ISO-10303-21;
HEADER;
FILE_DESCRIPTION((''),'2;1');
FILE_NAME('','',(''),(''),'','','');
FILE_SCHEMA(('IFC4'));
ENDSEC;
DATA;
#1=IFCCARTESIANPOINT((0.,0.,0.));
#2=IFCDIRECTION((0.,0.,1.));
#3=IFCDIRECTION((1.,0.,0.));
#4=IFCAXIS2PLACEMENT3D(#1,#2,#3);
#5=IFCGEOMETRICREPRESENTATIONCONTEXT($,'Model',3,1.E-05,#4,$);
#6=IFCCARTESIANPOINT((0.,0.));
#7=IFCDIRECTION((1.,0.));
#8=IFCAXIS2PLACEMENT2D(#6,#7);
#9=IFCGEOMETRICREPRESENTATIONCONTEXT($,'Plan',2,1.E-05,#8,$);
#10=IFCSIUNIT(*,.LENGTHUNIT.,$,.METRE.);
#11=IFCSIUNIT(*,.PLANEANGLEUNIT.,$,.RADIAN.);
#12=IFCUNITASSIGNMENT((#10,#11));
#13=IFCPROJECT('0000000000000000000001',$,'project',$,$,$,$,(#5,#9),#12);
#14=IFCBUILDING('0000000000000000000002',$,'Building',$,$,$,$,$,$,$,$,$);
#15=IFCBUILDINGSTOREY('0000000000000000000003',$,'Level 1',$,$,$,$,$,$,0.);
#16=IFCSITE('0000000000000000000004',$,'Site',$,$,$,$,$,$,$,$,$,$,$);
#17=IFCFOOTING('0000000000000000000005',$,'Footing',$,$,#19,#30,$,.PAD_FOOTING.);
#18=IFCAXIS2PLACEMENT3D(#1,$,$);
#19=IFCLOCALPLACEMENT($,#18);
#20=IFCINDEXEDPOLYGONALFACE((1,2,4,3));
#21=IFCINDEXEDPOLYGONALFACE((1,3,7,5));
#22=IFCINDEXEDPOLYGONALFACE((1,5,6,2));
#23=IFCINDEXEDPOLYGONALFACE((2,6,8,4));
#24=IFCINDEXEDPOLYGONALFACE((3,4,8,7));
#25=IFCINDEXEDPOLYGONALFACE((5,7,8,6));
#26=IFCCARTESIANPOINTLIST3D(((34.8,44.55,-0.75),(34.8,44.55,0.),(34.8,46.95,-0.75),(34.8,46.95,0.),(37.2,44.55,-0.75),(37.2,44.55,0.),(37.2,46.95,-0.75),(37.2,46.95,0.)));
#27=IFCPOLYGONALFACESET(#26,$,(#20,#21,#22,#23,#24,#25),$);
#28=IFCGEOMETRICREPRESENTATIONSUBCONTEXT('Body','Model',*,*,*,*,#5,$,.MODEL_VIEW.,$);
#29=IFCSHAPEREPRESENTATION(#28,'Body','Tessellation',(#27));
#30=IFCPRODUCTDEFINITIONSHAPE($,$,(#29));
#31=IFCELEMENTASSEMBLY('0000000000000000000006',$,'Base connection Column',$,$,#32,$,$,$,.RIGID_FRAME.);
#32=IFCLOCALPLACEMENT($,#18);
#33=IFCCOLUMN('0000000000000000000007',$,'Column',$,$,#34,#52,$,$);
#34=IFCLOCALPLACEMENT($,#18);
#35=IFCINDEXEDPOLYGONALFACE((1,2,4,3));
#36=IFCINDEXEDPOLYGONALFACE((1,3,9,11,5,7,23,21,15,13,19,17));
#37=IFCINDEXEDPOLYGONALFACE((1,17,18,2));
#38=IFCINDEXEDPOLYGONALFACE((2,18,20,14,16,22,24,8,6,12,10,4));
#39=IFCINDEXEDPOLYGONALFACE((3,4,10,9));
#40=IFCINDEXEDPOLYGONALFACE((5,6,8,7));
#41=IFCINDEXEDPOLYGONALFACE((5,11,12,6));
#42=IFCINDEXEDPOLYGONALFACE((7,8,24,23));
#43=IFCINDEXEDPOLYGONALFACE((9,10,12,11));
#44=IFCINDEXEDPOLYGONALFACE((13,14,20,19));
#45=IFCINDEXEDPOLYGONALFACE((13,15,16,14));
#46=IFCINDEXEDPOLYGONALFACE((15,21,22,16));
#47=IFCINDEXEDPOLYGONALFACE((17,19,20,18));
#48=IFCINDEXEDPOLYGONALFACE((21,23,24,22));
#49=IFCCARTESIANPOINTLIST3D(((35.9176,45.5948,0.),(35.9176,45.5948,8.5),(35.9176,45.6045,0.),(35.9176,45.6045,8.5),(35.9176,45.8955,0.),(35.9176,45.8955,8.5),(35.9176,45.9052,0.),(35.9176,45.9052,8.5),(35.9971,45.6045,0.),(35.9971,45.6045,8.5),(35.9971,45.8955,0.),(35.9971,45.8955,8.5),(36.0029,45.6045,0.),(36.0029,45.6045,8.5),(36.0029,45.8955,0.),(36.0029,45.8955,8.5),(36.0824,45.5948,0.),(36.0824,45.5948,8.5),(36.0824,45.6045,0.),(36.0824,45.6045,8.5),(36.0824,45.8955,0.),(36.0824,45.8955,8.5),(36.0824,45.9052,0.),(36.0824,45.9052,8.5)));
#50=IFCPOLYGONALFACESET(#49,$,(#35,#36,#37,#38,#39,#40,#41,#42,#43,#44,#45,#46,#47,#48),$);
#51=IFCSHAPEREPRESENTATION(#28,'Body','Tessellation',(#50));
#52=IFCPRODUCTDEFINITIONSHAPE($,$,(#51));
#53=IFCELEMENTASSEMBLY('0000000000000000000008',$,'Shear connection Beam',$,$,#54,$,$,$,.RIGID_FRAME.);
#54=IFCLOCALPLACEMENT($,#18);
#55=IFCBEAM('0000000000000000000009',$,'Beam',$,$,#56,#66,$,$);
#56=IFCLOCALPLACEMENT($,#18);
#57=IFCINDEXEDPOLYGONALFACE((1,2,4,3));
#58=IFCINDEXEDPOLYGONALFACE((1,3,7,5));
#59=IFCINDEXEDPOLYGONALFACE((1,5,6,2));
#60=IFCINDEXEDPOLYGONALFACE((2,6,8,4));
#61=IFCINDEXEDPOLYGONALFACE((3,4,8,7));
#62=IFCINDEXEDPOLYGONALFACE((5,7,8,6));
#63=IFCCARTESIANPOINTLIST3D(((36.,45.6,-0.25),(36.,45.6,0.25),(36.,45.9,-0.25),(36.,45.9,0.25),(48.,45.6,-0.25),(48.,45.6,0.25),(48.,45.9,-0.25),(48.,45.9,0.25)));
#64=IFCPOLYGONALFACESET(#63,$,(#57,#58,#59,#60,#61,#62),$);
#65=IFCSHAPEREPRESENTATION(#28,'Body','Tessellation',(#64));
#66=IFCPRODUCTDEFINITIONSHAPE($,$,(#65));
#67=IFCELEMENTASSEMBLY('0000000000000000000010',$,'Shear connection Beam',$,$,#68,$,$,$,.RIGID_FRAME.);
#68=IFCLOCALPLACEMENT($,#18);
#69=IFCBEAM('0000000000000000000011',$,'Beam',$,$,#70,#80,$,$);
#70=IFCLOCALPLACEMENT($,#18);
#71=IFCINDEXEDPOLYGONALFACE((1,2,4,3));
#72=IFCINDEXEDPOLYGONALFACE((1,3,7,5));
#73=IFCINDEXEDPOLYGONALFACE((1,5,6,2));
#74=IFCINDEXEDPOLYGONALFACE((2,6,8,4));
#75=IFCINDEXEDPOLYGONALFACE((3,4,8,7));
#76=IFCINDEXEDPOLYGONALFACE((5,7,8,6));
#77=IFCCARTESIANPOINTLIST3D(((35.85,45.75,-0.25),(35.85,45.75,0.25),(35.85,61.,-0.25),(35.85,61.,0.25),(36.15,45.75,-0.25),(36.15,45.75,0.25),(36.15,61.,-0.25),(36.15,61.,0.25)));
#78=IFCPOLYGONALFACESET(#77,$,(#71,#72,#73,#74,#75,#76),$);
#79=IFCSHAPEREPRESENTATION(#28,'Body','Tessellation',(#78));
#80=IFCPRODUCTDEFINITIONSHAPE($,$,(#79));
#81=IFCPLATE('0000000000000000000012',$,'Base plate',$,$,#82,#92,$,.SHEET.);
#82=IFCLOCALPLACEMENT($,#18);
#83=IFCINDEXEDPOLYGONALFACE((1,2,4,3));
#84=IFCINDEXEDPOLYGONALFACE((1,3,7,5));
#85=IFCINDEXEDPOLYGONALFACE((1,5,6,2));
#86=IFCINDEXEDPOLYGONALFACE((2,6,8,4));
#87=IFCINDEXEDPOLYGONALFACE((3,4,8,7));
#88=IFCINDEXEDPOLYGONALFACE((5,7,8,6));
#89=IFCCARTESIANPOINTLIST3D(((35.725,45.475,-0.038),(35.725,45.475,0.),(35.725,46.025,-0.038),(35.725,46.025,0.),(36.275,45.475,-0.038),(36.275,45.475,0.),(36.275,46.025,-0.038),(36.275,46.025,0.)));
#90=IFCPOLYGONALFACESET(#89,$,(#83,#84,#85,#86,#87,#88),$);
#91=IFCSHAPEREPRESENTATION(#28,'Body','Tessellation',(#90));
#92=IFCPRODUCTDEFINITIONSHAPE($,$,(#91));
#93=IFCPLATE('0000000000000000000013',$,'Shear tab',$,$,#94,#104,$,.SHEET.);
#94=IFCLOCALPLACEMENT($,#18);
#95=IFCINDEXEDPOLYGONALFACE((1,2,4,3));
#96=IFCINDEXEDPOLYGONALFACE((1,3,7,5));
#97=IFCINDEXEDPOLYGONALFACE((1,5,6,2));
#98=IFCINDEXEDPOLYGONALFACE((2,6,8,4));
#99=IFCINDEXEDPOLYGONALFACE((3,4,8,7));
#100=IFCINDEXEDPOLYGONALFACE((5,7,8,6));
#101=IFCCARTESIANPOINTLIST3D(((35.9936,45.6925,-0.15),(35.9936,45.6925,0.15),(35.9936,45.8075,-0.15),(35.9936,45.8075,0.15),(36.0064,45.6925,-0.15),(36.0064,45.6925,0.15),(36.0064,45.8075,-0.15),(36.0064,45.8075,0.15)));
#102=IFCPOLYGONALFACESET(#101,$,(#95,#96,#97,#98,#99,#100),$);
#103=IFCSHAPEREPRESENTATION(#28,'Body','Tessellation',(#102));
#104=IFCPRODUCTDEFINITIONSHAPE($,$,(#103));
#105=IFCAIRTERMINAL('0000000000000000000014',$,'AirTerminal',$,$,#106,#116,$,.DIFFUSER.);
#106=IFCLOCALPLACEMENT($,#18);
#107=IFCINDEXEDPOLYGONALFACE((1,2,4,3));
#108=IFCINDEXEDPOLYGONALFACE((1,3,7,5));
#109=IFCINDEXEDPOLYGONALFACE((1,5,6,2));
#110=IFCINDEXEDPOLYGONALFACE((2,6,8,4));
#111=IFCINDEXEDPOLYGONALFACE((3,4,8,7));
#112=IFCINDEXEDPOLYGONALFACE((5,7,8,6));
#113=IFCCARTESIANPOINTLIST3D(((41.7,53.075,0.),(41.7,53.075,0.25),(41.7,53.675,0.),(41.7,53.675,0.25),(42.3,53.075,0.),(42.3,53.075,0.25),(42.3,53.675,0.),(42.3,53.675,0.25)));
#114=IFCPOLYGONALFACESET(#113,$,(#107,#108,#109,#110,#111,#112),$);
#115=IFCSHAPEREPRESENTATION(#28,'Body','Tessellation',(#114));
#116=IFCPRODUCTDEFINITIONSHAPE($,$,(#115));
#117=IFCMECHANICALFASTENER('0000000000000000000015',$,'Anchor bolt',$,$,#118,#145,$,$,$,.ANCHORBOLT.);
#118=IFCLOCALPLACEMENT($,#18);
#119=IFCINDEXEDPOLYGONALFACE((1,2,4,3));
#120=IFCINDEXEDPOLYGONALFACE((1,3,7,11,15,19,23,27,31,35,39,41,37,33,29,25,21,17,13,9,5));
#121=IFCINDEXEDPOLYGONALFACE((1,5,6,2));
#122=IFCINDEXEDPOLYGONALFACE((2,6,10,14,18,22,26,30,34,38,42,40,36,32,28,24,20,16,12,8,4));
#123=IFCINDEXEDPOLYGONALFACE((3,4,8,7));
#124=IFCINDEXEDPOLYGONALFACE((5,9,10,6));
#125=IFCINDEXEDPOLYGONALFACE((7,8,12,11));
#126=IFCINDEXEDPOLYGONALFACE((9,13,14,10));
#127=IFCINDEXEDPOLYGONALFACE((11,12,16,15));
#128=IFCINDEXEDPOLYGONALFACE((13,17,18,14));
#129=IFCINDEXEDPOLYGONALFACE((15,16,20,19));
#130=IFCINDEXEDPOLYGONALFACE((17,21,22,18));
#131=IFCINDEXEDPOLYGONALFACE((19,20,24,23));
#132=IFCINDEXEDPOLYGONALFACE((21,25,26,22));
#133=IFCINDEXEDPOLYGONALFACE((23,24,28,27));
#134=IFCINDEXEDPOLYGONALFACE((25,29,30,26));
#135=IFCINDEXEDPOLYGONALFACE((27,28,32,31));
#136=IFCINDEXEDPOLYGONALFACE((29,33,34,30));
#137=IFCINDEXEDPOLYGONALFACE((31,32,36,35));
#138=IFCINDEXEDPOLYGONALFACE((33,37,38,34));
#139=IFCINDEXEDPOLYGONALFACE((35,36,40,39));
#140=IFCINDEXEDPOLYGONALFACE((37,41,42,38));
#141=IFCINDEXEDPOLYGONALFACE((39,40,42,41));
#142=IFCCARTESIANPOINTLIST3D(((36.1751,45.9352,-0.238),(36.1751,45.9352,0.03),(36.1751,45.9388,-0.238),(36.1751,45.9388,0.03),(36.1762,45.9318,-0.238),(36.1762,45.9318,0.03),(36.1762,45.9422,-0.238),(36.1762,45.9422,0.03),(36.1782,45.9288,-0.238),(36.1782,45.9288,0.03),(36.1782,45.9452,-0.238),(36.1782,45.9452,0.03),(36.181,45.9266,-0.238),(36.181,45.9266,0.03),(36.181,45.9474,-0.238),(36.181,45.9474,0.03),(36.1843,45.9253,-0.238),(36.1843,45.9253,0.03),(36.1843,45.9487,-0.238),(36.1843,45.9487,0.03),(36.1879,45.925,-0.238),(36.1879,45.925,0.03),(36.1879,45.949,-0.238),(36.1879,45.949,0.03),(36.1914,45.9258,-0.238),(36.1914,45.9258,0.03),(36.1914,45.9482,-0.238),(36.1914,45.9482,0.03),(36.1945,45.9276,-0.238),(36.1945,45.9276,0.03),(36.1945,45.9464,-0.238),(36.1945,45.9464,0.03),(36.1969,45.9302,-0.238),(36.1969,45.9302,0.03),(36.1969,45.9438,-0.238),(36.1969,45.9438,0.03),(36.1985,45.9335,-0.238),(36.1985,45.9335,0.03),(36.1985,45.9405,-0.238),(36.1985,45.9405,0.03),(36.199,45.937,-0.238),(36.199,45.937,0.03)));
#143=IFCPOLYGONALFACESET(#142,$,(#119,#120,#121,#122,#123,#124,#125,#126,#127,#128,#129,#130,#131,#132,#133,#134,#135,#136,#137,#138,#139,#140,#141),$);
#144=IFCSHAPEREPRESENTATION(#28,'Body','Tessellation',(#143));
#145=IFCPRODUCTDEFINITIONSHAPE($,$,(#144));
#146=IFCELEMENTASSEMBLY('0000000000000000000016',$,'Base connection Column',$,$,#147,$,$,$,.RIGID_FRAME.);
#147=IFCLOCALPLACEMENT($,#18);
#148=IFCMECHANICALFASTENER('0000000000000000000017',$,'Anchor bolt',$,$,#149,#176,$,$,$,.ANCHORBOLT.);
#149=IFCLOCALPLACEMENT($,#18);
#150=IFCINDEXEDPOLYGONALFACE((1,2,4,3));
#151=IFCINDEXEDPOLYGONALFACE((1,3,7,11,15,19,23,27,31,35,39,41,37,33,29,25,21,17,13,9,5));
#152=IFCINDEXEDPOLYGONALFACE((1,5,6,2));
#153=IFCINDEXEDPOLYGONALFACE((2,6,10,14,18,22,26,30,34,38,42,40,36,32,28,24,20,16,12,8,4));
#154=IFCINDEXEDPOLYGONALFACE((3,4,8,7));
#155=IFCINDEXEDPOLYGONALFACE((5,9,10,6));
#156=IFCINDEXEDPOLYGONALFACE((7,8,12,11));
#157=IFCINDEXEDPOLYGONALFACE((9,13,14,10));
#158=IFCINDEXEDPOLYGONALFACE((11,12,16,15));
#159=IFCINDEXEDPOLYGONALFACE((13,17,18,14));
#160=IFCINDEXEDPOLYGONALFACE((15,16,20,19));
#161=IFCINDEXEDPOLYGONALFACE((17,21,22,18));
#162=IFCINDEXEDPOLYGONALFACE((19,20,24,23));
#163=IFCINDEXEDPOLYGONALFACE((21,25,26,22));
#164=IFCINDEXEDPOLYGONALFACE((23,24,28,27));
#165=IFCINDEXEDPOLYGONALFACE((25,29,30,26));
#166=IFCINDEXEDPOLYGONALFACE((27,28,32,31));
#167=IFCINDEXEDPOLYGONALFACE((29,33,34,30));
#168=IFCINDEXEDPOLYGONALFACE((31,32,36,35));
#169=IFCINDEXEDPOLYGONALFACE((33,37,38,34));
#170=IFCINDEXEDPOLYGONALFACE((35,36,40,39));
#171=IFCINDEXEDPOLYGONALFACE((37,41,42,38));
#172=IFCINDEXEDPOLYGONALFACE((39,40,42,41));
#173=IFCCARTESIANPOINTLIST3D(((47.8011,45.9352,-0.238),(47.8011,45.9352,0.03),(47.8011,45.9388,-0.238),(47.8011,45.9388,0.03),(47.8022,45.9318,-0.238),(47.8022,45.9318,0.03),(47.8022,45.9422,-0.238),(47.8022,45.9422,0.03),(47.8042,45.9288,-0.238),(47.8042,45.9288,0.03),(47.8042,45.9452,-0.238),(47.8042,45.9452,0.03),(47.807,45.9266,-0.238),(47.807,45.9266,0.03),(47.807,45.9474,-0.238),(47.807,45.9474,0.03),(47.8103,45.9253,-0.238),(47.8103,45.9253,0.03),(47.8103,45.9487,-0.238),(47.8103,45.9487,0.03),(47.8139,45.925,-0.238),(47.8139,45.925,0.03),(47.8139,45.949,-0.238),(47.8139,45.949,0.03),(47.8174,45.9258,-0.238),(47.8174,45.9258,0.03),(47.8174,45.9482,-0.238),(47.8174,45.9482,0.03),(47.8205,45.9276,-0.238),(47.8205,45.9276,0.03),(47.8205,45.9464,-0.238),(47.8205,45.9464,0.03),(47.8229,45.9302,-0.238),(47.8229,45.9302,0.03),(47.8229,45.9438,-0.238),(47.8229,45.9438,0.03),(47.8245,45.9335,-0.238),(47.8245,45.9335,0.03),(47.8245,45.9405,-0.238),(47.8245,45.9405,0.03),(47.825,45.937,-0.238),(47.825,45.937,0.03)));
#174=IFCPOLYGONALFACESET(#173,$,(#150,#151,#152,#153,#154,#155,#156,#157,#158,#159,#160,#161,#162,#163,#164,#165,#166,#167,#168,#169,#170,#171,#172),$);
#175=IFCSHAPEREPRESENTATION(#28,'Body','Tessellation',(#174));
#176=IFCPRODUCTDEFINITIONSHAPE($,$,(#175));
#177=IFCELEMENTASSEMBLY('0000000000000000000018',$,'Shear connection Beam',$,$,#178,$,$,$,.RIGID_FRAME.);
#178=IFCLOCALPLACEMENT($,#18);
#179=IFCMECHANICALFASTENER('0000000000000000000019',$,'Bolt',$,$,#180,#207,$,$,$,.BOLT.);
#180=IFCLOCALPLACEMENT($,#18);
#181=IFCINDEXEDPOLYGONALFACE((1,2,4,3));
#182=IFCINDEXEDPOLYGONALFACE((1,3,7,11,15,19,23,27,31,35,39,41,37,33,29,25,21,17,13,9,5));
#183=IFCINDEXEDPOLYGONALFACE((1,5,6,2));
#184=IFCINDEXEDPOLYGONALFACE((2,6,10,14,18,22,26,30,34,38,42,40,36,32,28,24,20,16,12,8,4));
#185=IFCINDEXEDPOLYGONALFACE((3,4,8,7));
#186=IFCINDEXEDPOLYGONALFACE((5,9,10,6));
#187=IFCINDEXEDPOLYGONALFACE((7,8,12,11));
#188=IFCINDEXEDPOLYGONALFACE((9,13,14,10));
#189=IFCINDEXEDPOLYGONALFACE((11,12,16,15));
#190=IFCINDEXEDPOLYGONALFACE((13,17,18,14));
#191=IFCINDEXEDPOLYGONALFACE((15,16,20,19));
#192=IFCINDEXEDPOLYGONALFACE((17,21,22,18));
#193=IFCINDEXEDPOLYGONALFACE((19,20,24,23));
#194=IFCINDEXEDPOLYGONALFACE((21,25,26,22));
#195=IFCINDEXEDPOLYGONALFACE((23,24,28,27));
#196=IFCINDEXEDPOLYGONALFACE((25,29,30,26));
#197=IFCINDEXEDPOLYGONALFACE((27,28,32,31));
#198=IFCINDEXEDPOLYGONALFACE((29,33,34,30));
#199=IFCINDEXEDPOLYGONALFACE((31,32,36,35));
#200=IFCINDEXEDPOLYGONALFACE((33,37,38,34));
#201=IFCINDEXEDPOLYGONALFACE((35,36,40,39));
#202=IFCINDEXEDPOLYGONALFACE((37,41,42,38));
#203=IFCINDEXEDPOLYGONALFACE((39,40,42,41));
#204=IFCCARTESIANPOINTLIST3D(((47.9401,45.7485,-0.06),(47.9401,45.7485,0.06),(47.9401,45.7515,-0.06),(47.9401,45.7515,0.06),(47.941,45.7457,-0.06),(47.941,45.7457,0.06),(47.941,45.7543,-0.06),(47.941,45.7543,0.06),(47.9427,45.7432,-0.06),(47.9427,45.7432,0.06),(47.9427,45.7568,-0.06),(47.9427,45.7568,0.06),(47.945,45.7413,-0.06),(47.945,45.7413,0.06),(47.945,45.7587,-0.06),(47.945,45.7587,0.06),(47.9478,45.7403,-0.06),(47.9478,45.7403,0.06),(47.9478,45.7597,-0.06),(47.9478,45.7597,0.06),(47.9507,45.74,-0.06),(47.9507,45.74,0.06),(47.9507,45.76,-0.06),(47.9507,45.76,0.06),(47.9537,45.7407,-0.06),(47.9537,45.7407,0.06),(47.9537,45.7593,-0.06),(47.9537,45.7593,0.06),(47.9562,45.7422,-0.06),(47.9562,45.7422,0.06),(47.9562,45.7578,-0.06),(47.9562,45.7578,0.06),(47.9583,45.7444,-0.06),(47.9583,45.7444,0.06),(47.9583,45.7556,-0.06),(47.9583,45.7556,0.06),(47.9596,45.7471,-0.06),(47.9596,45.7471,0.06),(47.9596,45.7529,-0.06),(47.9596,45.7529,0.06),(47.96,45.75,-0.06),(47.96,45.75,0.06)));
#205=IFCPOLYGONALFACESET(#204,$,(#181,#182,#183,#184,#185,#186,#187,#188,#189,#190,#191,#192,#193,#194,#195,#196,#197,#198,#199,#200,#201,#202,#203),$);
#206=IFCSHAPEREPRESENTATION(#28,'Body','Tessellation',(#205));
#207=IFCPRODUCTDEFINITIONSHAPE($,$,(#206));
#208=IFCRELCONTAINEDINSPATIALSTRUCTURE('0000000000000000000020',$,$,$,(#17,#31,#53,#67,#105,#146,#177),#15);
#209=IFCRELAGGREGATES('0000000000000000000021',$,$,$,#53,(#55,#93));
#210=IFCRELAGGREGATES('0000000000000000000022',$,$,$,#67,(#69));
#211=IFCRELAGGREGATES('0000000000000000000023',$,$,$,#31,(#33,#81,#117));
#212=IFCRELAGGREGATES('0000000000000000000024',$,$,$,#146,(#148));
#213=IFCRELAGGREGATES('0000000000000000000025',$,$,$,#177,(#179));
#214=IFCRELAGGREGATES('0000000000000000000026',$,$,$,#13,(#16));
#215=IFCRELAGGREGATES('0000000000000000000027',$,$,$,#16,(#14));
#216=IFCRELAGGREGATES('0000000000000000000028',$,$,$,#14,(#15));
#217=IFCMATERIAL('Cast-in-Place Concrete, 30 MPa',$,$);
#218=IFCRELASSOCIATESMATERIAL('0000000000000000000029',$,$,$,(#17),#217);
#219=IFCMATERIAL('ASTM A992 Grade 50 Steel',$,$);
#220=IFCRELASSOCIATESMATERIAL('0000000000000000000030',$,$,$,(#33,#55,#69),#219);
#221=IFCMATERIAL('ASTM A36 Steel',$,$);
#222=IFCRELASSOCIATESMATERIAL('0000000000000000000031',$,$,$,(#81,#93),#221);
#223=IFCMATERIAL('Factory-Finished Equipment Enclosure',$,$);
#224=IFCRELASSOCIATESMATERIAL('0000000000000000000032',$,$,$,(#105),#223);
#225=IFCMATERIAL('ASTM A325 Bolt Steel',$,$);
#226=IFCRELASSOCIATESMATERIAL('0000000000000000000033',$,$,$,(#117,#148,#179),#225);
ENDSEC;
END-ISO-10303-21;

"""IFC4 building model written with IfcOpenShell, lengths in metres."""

from ifc_helpers import new_model, si_unit, frame, origin_with_axes, origin_2d, origin_2d_with_axis, place, context, subcontext, project, spatial, rectangle, circle, i_section, extrude, material, element, aggregate, save


model = new_model("IFC4")

# Units and contexts
model_context = context("Model", 3, precision=1e-05, world=origin_with_axes())
plan_context = context("Plan", 2, precision=1e-05, world=origin_2d_with_axis())
body_context = subcontext(model_context, "Body", "Model", "MODEL_VIEW")
ifc_project = project(units=[si_unit("LENGTHUNIT", "METRE"), si_unit("PLANEANGLEUNIT", "RADIAN")], contexts=[model_context, plan_context])

# Site, building, storey
site = spatial("IfcSite", under=ifc_project, Name="Site")
building = spatial("IfcBuilding", under=site, Name="Building")
storey = spatial("IfcBuildingStorey", under=building, Name="Level 1", Elevation=0.0)

# Footing
ifc_material_1 = material(Name="Cast-in-Place Concrete, 30 MPa")
footing_placement = place(None, frame((36.0, 45.75, -0.75), z_axis=(0.0, 0.0, 1.0), x_axis=(1.0, 0.0, 0.0)))
element("IfcFooting", 1, at=footing_placement, inside=storey, material=ifc_material_1, Name="Footing", PredefinedType="PAD_FOOTING", context=body_context, shape_type="SweptSolid", body=[
    extrude(rectangle(XDim=2.4, YDim=2.4, at=origin_2d_with_axis()), origin_with_axes(), (0.0, 0.0, 1.0), 0.75),
])

# Element assembly, column
assembly_1 = element("IfcElementAssembly", 2, inside=storey, Name="Base connection Column", PredefinedType="RIGID_FRAME")
ifc_material_2 = material(Name="ASTM A992 Grade 50 Steel")
column_placement = place(None, frame((36.0, 45.75, 0.0), z_axis=(0.0, 0.0, 1.0), x_axis=(1.0, 0.0, 0.0)))
column = element("IfcColumn", 3, at=column_placement, material=ifc_material_2, Name="Column", context=body_context, shape_type="SweptSolid", body=[
    extrude(i_section(OverallWidth=0.1648, OverallDepth=0.3104, WebThickness=0.0058, FlangeThickness=0.0097, at=origin_2d_with_axis()), origin_with_axes(), (0.0, 0.0, 1.0), 8.5),
])

# Element assemblies, beams
assembly_2 = element("IfcElementAssembly", 4, inside=storey, Name="Shear connection Beam", PredefinedType="RIGID_FRAME")
beam_1_placement = place(None, frame((36.0, 45.75, 0.0), z_axis=(1.0, 0.0, 0.0), x_axis=(0.0, 1.0, 0.0)))
beam_1 = element("IfcBeam", 5, at=beam_1_placement, material=ifc_material_2, Name="Beam", context=body_context, shape_type="SweptSolid", body=[
    extrude(rectangle(XDim=0.3, YDim=0.5, at=origin_2d_with_axis()), origin_with_axes(), (0.0, 0.0, 1.0), 12.0),
])
assembly_3 = element("IfcElementAssembly", 6, inside=storey, Name="Shear connection Beam", PredefinedType="RIGID_FRAME")
beam_2_placement = place(None, frame((36.0, 45.75, 0.0), z_axis=(0.0, 1.0, 0.0), x_axis=(-1.0, 0.0, 0.0)))
beam_2 = element("IfcBeam", 7, at=beam_2_placement, material=ifc_material_2, Name="Beam", context=body_context, shape_type="SweptSolid", body=[
    extrude(rectangle(XDim=0.3, YDim=0.5, at=origin_2d_with_axis()), origin_with_axes(), (0.0, 0.0, 1.0), 15.25),
])

# Plates
ifc_material_3 = material(Name="ASTM A36 Steel")
plate_1_placement = place(None, frame((36.0, 45.75, -0.038), z_axis=(0.0, 0.0, 1.0), x_axis=(1.0, 0.0, 0.0)))
plate_1 = element("IfcPlate", 8, at=plate_1_placement, material=ifc_material_3, Name="Base plate", PredefinedType="SHEET", context=body_context, shape_type="SweptSolid", body=[
    extrude(rectangle(XDim=0.55, YDim=0.55, at=origin_2d_with_axis()), origin_with_axes(), (0.0, 0.0, 1.0), 0.038),
])
plate_2_placement = place(None, frame((36.0, 45.75, -0.15), z_axis=(0.0, 0.0, 1.0), x_axis=(1.0, 0.0, 0.0)))
plate_2 = element("IfcPlate", 9, at=plate_2_placement, material=ifc_material_3, Name="Shear tab", PredefinedType="SHEET", context=body_context, shape_type="SweptSolid", body=[
    extrude(rectangle(XDim=0.0127, YDim=0.115, at=origin_2d_with_axis()), origin_with_axes(), (0.0, 0.0, 1.0), 0.3),
])
aggregate(assembly_2, [beam_1, plate_2])
aggregate(assembly_3, [beam_2])

# Air terminal
ifc_material_4 = material(Name="Factory-Finished Equipment Enclosure")
air_terminal_placement = place(None, frame((42.0, 53.375, 0.0), z_axis=(0.0, 0.0, 1.0), x_axis=(1.0, 0.0, 0.0)))
element("IfcAirTerminal", 10, at=air_terminal_placement, inside=storey, material=ifc_material_4, Name="AirTerminal", PredefinedType="DIFFUSER", context=body_context, shape_type="SweptSolid", body=[
    extrude(rectangle(XDim=0.6, YDim=0.6, at=origin_2d_with_axis()), origin_with_axes(), (0.0, 0.0, 1.0), 0.25),
])

# Mechanical fastener
ifc_material_5 = material(Name="ASTM A325 Bolt Steel")
mechanical_fastener_1_placement = place(None, frame((36.187, 45.937, -0.238), z_axis=(0.0, 0.0, 1.0), x_axis=(1.0, 0.0, 0.0)))
mechanical_fastener_1 = element("IfcMechanicalFastener", 11, at=mechanical_fastener_1_placement, material=ifc_material_5, Name="Anchor bolt", PredefinedType="ANCHORBOLT", context=body_context, shape_type="SweptSolid", body=[
    extrude(circle(Radius=0.012, at=origin_2d()), origin_with_axes(), (0.0, 0.0, 1.0), 0.268),
])
aggregate(assembly_1, [column, plate_1, mechanical_fastener_1])

# Element assembly, mechanical fastener
assembly_4 = element("IfcElementAssembly", 12, inside=storey, Name="Base connection Column", PredefinedType="RIGID_FRAME")
mechanical_fastener_2_placement = place(None, frame((47.813, 45.937, -0.238), z_axis=(0.0, 0.0, 1.0), x_axis=(1.0, 0.0, 0.0)))
mechanical_fastener_2 = element("IfcMechanicalFastener", 13, at=mechanical_fastener_2_placement, material=ifc_material_5, Name="Anchor bolt", PredefinedType="ANCHORBOLT", context=body_context, shape_type="SweptSolid", body=[
    extrude(circle(Radius=0.012, at=origin_2d()), origin_with_axes(), (0.0, 0.0, 1.0), 0.268),
])
aggregate(assembly_4, [mechanical_fastener_2])

# Element assembly, mechanical fastener
assembly_5 = element("IfcElementAssembly", 14, inside=storey, Name="Shear connection Beam", PredefinedType="RIGID_FRAME")
mechanical_fastener_3_placement = place(None, frame((47.95, 45.75, -0.06), z_axis=(0.0, 0.0, 1.0), x_axis=(1.0, 0.0, 0.0)))
mechanical_fastener_3 = element("IfcMechanicalFastener", 15, at=mechanical_fastener_3_placement, material=ifc_material_5, Name="Bolt", PredefinedType="BOLT", context=body_context, shape_type="SweptSolid", body=[
    extrude(circle(Radius=0.01, at=origin_2d()), origin_with_axes(), (0.0, 0.0, 1.0), 0.12),
])
aggregate(assembly_5, [mechanical_fastener_3])

save(model, "model.ifc")
